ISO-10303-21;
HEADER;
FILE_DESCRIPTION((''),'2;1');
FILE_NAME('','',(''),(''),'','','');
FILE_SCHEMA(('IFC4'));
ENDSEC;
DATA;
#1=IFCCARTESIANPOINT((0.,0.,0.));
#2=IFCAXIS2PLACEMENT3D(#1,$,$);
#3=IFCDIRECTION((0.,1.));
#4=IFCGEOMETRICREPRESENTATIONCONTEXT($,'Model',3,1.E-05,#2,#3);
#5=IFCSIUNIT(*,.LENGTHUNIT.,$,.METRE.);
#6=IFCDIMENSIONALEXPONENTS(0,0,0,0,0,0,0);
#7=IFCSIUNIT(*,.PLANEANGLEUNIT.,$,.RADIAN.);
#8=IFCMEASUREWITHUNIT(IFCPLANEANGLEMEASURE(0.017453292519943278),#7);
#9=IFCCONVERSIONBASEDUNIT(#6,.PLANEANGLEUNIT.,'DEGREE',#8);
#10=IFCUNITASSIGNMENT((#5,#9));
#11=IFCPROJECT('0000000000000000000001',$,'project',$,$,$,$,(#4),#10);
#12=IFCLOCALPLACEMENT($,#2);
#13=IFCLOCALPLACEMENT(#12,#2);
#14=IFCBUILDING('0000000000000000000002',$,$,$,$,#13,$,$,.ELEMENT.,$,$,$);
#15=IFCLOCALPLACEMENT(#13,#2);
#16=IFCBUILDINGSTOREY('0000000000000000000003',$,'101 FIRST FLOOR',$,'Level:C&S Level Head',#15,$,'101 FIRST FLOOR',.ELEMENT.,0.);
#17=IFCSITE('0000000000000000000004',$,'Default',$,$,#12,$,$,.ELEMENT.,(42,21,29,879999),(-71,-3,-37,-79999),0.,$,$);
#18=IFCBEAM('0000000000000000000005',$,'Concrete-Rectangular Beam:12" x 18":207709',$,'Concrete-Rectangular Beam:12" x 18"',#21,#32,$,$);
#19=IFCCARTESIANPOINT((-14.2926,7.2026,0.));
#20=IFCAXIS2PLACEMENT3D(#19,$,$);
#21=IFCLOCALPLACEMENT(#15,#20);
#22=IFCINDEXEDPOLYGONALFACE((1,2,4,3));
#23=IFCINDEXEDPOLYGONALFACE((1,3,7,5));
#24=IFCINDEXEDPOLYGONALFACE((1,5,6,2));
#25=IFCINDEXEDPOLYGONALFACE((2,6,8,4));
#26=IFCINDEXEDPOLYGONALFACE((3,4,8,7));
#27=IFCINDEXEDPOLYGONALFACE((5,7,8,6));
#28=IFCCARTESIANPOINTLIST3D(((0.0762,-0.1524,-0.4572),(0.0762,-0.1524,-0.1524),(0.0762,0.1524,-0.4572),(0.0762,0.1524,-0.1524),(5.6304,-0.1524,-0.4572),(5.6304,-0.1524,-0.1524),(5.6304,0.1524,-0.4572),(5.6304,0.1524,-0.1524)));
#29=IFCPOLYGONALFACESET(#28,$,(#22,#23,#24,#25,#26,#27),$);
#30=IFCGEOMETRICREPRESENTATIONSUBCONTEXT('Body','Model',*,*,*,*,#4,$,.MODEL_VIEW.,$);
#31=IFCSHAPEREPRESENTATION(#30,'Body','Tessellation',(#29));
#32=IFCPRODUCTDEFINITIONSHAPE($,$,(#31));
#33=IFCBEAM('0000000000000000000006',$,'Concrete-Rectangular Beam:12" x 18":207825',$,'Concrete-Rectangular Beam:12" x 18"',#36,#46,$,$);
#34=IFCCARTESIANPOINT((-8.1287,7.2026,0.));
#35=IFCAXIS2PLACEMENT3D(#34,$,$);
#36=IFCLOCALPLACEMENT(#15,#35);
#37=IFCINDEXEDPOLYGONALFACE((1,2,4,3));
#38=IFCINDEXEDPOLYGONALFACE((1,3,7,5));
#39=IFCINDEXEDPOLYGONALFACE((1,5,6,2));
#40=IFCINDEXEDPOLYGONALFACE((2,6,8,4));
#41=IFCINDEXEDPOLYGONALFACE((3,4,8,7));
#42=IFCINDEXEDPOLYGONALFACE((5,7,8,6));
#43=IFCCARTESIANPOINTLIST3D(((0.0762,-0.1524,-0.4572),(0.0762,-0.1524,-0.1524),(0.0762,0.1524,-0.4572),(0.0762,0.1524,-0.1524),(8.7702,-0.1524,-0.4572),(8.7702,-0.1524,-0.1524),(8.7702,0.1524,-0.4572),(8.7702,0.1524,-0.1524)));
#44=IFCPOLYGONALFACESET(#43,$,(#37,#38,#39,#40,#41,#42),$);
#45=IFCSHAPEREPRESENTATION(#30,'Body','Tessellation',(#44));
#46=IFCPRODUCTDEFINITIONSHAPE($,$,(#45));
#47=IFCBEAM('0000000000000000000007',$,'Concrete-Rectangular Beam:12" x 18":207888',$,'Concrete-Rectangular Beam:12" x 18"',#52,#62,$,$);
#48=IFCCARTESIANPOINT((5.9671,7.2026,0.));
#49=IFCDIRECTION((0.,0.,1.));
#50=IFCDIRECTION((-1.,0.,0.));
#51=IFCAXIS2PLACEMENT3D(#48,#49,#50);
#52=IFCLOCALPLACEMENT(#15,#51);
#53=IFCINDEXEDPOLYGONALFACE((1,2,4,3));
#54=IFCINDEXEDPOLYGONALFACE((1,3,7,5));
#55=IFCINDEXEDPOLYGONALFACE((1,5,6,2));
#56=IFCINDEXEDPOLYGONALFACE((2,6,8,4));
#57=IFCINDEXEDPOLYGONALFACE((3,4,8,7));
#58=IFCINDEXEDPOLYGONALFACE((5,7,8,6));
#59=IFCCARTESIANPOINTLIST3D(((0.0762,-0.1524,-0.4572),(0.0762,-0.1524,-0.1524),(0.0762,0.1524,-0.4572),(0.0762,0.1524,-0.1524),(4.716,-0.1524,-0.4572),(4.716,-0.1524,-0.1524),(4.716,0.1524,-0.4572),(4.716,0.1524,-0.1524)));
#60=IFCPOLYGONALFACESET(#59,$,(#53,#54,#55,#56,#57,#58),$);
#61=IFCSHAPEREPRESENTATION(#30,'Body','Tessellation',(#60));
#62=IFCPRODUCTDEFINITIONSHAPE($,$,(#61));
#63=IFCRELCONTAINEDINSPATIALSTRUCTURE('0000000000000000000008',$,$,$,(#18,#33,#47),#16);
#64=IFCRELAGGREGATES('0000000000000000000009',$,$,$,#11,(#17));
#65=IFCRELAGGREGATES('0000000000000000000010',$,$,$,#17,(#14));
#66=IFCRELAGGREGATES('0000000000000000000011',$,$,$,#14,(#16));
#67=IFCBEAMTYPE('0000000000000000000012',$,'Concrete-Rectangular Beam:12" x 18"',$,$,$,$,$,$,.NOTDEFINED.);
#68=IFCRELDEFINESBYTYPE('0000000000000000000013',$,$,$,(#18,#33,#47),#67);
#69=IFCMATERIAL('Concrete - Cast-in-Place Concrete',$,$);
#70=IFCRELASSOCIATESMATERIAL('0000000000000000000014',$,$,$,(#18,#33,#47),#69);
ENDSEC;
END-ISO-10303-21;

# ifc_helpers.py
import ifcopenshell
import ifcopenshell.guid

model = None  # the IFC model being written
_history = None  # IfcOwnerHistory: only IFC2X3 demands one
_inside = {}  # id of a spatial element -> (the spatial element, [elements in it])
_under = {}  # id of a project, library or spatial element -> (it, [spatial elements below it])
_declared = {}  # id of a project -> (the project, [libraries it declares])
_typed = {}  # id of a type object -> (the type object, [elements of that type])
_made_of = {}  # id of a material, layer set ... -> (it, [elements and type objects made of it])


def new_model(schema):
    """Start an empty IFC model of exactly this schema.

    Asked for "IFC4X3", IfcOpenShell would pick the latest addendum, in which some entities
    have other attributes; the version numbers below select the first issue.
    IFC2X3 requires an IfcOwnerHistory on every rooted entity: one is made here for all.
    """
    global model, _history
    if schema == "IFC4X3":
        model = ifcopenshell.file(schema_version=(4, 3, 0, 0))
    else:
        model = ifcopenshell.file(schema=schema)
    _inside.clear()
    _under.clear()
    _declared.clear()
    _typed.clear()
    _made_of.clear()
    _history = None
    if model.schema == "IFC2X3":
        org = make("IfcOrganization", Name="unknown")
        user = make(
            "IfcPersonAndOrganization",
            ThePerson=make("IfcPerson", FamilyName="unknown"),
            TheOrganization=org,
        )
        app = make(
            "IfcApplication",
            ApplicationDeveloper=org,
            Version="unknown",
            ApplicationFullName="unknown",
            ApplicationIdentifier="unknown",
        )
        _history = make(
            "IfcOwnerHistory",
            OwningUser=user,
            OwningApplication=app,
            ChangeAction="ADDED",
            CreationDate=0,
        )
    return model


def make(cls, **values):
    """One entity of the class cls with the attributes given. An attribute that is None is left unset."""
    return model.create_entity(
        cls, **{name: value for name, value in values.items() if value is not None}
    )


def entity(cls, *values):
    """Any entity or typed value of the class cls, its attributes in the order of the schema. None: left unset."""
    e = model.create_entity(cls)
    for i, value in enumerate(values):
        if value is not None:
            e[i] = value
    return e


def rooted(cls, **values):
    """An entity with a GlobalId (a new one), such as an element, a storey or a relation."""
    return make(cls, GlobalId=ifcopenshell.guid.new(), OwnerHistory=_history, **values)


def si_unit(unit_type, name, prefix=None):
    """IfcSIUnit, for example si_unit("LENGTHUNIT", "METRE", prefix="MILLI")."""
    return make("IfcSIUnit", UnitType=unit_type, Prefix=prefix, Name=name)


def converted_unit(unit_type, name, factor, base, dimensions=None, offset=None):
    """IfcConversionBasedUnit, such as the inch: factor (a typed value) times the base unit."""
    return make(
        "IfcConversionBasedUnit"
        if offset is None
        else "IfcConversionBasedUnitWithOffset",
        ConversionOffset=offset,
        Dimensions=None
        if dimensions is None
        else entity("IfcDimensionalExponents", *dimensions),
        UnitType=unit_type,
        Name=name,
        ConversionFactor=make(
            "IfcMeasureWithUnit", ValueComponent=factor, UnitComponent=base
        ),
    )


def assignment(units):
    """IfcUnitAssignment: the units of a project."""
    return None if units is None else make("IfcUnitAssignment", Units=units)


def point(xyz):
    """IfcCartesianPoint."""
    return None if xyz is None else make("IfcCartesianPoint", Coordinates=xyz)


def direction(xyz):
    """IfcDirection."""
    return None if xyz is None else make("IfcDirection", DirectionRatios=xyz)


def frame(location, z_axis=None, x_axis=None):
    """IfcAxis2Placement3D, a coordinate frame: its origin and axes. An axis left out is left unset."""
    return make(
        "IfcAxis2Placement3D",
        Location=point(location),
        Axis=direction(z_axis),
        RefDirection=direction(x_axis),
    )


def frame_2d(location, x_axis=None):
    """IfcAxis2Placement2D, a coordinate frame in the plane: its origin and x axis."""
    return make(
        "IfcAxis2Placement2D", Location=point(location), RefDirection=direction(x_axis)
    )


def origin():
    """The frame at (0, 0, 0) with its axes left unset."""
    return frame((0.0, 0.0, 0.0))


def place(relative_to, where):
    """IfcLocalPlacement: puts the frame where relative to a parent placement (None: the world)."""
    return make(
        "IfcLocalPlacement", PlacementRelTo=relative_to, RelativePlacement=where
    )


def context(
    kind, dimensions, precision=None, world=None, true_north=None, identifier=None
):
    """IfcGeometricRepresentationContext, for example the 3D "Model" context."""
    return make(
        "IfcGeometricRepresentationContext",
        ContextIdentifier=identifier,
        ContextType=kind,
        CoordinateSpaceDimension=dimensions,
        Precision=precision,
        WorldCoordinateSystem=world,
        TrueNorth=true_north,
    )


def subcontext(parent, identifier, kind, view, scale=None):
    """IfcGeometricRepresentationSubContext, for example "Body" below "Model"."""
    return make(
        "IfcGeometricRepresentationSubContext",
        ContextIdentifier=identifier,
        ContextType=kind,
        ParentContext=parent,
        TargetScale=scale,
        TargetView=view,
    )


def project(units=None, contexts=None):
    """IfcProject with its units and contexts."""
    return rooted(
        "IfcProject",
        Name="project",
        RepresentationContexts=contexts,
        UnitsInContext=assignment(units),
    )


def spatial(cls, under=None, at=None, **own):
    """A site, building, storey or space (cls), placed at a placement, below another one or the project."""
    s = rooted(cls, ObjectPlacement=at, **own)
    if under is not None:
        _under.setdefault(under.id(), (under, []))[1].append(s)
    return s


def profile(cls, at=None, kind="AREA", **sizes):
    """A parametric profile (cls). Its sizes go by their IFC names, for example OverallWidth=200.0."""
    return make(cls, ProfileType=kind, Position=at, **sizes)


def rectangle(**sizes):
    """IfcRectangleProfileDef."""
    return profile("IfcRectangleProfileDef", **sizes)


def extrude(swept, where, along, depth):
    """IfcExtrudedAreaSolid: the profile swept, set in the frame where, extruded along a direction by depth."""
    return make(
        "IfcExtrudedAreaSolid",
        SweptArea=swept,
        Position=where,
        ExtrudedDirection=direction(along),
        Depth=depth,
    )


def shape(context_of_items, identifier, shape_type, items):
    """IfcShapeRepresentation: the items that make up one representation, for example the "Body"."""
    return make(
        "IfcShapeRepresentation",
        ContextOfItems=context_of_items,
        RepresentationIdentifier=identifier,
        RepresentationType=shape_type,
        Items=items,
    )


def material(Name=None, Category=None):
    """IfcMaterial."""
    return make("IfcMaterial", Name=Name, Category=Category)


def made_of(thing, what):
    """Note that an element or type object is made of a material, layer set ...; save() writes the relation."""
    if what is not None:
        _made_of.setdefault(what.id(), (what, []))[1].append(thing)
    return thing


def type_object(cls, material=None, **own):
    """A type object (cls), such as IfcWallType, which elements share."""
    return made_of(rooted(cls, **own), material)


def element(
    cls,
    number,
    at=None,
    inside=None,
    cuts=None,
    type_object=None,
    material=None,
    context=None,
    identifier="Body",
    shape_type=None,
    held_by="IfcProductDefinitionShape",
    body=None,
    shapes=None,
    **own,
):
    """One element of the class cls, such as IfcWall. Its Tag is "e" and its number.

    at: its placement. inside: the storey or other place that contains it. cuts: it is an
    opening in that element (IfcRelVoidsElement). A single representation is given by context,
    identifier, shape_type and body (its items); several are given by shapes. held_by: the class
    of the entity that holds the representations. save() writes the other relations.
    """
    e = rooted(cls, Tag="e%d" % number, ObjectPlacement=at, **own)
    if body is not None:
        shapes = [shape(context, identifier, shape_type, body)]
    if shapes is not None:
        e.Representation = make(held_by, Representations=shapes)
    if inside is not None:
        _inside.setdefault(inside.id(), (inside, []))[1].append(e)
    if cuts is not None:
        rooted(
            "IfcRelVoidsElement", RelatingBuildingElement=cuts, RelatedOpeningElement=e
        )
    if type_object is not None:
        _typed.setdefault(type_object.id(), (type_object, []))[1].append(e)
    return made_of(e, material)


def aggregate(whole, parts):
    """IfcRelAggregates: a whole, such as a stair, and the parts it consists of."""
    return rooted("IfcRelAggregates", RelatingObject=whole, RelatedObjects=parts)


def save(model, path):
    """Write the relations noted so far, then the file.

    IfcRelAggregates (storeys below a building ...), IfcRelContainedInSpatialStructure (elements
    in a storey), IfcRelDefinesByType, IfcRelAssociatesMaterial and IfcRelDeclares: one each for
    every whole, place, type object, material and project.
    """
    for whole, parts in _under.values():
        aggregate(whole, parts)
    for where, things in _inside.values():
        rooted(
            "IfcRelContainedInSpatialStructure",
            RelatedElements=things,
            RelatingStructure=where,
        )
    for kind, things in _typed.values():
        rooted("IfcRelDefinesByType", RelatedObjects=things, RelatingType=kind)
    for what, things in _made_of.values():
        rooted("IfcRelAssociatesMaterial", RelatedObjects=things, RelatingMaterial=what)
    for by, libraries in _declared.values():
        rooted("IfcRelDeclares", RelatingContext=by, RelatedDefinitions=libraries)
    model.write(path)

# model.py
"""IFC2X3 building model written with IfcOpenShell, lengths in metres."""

from ifc_helpers import new_model, entity, si_unit, converted_unit, direction, frame, frame_2d, origin, place, context, subcontext, project, spatial, rectangle, extrude, material, type_object, element, save


model = new_model("IFC2X3")

# Units and contexts
model_context = context("Model", 3, precision=1e-05, world=origin(), true_north=direction((0.0, 1.0)))
body_context = subcontext(model_context, "Body", "Model", "MODEL_VIEW")
ifc_project = project(units=[si_unit("LENGTHUNIT", "METRE"), converted_unit("PLANEANGLEUNIT", "DEGREE", entity("IfcPlaneAngleMeasure", 0.017453292519943278), si_unit("PLANEANGLEUNIT", "RADIAN"), dimensions=[0, 0, 0, 0, 0, 0, 0])], contexts=[model_context])

# Site, building, storey
site_placement = place(None, origin())
site = spatial("IfcSite", under=ifc_project, at=site_placement, Name="Default", CompositionType="ELEMENT", RefLatitude=(42, 21, 29, 879999), RefLongitude=(-71, -3, -37, -79999), RefElevation=0.0)
building_placement = place(site_placement, origin())
building = spatial("IfcBuilding", under=site, at=building_placement, CompositionType="ELEMENT")
storey_placement = place(building_placement, origin())
storey = spatial("IfcBuildingStorey", under=building, at=storey_placement, Name="101 FIRST FLOOR", ObjectType="Level:C&S Level Head", LongName="101 FIRST FLOOR", CompositionType="ELEMENT", Elevation=0.0)

# Shared definitions
ifc_material = material(Name="Concrete - Cast-in-Place Concrete")

# Beams
beam_type = type_object("IfcBeamType", Name="Concrete-Rectangular Beam:12\" x 18\"", PredefinedType="NOTDEFINED")
beam_1_placement = place(storey_placement, frame((-14.2926, 7.2026, 0.0)))
element("IfcBeam", 1, at=beam_1_placement, inside=storey, type_object=beam_type, material=ifc_material, Name="Concrete-Rectangular Beam:12\" x 18\":207709", ObjectType="Concrete-Rectangular Beam:12\" x 18\"", context=body_context, shape_type="SweptSolid", body=[
    extrude(rectangle(XDim=0.3048, YDim=0.3048, at=frame_2d((0.0, 0.0), x_axis=(1.0, 0.0))), frame((0.0762, 0.0, -0.3048), z_axis=(1.0, 0.0, 0.0), x_axis=(0.0, 0.0, -1.0)), (0.0, 0.0, 1.0), 5.5542),
])
beam_2_placement = place(storey_placement, frame((-8.1287, 7.2026, 0.0)))
element("IfcBeam", 2, at=beam_2_placement, inside=storey, type_object=beam_type, material=ifc_material, Name="Concrete-Rectangular Beam:12\" x 18\":207825", ObjectType="Concrete-Rectangular Beam:12\" x 18\"", context=body_context, shape_type="SweptSolid", body=[
    extrude(rectangle(XDim=0.3048, YDim=0.3048, at=frame_2d((0.0, 0.0), x_axis=(1.0, 0.0))), frame((0.0762, 0.0, -0.3048), z_axis=(1.0, 0.0, 0.0), x_axis=(0.0, 0.0, -1.0)), (0.0, 0.0, 1.0), 8.694),
])
beam_3_placement = place(storey_placement, frame((5.9671, 7.2026, 0.0), z_axis=(0.0, 0.0, 1.0), x_axis=(-1.0, 0.0, 0.0)))
element("IfcBeam", 3, at=beam_3_placement, inside=storey, type_object=beam_type, material=ifc_material, Name="Concrete-Rectangular Beam:12\" x 18\":207888", ObjectType="Concrete-Rectangular Beam:12\" x 18\"", context=body_context, shape_type="SweptSolid", body=[
    extrude(rectangle(XDim=0.3048, YDim=0.3048, at=frame_2d((0.0, 0.0), x_axis=(1.0, 0.0))), frame((0.0762, 0.0, -0.3048), z_axis=(1.0, 0.0, 0.0), x_axis=(0.0, 0.0, -1.0)), (0.0, 0.0, 1.0), 4.6398),
])

save(model, "model.ifc")
